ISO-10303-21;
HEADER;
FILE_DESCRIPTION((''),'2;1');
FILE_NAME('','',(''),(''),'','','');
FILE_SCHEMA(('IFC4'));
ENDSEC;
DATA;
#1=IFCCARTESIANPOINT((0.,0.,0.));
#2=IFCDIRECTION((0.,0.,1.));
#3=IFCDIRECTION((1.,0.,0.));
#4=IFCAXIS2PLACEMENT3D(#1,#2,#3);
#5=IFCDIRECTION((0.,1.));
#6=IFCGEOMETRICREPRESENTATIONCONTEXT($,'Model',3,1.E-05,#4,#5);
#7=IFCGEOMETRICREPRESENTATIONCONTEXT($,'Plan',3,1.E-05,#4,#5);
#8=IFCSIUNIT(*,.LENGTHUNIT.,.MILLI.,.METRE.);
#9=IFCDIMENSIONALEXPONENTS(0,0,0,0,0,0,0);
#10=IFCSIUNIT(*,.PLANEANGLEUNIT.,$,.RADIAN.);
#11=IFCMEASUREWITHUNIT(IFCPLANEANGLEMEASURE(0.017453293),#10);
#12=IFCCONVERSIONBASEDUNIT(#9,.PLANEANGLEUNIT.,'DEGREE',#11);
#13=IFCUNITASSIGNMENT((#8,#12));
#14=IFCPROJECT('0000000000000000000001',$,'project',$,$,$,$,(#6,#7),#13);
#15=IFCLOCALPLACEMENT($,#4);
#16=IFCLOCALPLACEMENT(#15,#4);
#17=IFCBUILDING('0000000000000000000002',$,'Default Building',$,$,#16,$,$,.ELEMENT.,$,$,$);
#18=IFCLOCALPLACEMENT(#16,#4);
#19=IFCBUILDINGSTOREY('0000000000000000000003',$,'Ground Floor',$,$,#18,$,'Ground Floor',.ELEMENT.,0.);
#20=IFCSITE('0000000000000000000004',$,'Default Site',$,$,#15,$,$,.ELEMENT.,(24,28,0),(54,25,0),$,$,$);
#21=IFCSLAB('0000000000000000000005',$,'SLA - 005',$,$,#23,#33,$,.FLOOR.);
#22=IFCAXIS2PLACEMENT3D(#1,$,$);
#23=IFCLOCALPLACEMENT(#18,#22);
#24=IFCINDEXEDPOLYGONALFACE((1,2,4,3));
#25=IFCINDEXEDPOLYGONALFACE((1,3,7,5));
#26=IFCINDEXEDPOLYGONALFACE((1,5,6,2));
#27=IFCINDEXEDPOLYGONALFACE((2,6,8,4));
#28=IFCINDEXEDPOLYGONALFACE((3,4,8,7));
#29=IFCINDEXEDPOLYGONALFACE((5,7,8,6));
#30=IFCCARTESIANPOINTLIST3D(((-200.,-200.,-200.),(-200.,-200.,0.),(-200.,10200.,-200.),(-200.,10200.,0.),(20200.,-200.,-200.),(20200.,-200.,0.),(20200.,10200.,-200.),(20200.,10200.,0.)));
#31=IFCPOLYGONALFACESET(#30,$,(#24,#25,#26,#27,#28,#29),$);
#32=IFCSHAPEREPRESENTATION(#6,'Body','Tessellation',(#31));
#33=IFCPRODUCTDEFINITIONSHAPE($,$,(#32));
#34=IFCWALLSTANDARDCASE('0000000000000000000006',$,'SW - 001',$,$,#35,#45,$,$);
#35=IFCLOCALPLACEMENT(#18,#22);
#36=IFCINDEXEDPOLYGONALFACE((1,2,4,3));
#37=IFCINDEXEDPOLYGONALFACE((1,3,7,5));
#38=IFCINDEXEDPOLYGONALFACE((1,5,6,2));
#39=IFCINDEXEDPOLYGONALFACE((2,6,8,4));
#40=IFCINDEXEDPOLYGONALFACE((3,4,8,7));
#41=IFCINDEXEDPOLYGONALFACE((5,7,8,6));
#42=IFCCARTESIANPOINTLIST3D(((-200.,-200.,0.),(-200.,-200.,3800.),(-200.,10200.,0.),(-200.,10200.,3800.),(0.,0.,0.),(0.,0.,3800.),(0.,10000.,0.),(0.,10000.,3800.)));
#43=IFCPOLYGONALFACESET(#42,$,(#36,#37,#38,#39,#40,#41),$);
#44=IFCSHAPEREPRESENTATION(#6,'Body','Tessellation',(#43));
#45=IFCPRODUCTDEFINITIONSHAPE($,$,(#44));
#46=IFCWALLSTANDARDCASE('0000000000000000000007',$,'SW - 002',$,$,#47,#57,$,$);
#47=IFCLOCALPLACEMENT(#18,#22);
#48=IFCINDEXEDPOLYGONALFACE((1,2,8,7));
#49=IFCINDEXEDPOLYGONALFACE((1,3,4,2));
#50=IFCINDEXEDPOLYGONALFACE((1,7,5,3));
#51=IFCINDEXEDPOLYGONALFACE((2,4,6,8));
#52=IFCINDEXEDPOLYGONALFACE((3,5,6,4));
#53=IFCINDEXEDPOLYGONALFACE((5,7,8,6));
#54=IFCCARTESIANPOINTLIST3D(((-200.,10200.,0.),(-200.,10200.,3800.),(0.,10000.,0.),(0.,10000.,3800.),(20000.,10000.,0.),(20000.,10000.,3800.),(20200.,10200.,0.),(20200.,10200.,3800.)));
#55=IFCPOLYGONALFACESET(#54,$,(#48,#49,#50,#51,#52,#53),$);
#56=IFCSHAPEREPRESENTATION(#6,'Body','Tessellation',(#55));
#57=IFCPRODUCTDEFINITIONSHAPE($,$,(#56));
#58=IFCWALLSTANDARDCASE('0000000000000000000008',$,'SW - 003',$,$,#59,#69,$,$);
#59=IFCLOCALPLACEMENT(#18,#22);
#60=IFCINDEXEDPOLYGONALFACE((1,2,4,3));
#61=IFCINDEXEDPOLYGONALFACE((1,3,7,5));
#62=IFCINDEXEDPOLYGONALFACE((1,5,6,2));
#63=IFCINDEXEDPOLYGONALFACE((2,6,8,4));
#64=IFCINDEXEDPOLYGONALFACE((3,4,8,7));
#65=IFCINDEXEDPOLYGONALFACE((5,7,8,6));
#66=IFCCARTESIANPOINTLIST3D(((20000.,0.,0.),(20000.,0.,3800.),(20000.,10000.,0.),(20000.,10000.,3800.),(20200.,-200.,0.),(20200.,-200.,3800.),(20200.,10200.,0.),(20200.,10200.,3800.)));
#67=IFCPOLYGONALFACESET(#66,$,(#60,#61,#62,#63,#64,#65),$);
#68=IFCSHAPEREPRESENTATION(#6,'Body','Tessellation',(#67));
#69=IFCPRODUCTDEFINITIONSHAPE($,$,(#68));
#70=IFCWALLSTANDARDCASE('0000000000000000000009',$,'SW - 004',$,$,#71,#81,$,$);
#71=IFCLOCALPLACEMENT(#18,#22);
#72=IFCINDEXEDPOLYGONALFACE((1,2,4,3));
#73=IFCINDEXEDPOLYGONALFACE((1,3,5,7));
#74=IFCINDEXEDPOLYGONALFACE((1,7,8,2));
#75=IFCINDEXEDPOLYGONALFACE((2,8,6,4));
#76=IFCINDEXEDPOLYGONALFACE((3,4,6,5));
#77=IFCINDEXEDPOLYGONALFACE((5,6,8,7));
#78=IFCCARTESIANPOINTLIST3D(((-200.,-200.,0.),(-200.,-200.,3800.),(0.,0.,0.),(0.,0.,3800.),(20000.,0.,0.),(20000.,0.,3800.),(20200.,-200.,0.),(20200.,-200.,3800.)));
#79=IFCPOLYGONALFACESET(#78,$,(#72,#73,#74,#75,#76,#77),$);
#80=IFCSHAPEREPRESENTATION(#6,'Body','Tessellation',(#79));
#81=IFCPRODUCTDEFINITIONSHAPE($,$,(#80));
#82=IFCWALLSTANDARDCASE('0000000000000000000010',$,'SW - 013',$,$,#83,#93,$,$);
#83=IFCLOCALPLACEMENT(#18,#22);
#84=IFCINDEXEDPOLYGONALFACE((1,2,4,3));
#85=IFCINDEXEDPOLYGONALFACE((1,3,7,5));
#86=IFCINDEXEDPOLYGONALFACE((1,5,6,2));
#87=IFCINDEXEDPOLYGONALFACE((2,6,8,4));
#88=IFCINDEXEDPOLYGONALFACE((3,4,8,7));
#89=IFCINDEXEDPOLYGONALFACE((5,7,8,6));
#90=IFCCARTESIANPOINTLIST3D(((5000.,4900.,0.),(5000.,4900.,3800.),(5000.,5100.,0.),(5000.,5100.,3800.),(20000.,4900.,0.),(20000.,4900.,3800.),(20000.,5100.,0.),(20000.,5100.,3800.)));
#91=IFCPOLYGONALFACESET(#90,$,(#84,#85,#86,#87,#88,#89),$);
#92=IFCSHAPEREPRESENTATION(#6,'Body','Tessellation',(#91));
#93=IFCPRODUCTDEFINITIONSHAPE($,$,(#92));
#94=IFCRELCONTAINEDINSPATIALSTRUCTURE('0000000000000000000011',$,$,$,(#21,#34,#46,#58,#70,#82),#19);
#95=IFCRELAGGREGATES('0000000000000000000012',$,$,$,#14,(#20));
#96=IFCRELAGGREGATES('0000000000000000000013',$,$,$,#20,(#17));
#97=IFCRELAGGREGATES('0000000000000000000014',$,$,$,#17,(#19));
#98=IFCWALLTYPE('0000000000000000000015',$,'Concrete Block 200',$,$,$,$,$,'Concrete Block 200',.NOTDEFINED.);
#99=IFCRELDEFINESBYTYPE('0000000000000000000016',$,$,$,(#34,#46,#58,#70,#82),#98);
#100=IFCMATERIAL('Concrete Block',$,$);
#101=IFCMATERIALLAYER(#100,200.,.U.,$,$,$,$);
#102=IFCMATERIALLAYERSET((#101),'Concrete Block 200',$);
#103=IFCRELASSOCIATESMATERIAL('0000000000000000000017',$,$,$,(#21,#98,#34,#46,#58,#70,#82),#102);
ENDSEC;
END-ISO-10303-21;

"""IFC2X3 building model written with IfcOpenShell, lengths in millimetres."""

from ifc_helpers import new_model, entity, si_unit, converted_unit, direction, frame, origin_with_axes, place, context, project, spatial, polyline, outline, extrude, material, layer, layer_set, layer_usage, type_object, element, save


model = new_model("IFC2X3")

# Units and contexts
model_context = context("Model", 3, precision=1e-05, world=origin_with_axes(), true_north=direction((0.0, 1.0)))
plan_context = context("Plan", 3, precision=1e-05, world=origin_with_axes(), true_north=direction((0.0, 1.0)))
ifc_project = project(units=[si_unit("LENGTHUNIT", "METRE", prefix="MILLI"), converted_unit("PLANEANGLEUNIT", "DEGREE", entity("IfcPlaneAngleMeasure", 0.017453293), si_unit("PLANEANGLEUNIT", "RADIAN"), dimensions=[0, 0, 0, 0, 0, 0, 0])], contexts=[model_context, plan_context])

# Site, building, storey
site_placement = place(None, origin_with_axes())
site = spatial("IfcSite", under=ifc_project, at=site_placement, Name="Default Site", CompositionType="ELEMENT", RefLatitude=(24, 28, 0), RefLongitude=(54, 25, 0))
building_placement = place(site_placement, origin_with_axes())
building = spatial("IfcBuilding", under=site, at=building_placement, Name="Default Building", CompositionType="ELEMENT")
storey_placement = place(building_placement, origin_with_axes())
storey = spatial("IfcBuildingStorey", under=building, at=storey_placement, Name="Ground Floor", LongName="Ground Floor", CompositionType="ELEMENT", Elevation=0.0)

# Slab
ifc_material = material(Name="Concrete Block")
ifc_layer = layer(ifc_material, 200.0, ventilated="UNKNOWN")
ifc_layer_set = layer_set([ifc_layer], Name="Concrete Block 200")
ifc_layer_usage_1 = layer_usage(ifc_layer_set, "AXIS3", "NEGATIVE", 200.0)
slab_placement = place(storey_placement, frame((-200.0, 10200.0, -200.0), z_axis=(0.0, 0.0, 1.0), x_axis=(1.0, 0.0, 0.0)))
element("IfcSlab", 1, at=slab_placement, inside=storey, material=ifc_layer_usage_1, Name="SLA - 005", PredefinedType="FLOOR", context=model_context, shape_type="SweptSolid", body=[
    extrude(outline(polyline([(0.0, 0.0), (20400.0, 0.0), (20400.0, -10400.0), (0.0, -10400.0), (0.0, 0.0)])), origin_with_axes(), (0.0, 0.0, 1.0), 200.0),
])

# Walls
ifc_layer_usage_2 = layer_usage(ifc_layer_set, "AXIS2", "POSITIVE", 0.0)
wall_type = type_object("IfcWallType", Name="Concrete Block 200", ElementType="Concrete Block 200", PredefinedType="NOTDEFINED", material=ifc_layer_set)
wall_1_placement = place(storey_placement, frame((0.0, 0.0, 0.0), z_axis=(0.0, 0.0, 1.0), x_axis=(0.0, 1.0, 0.0)))
element("IfcWallStandardCase", 2, at=wall_1_placement, inside=storey, type_object=wall_type, material=ifc_layer_usage_2, Name="SW - 001", context=model_context, shape_type="SweptSolid", body=[
    extrude(outline(polyline([(0.0, 0.0), (10000.0, 0.0), (10200.0, 200.0), (-200.0, 200.0), (0.0, 0.0)])), origin_with_axes(), (0.0, 0.0, 1.0), 3800.0),
])
ifc_layer_usage_3 = layer_usage(ifc_layer_set, "AXIS2", "POSITIVE", 0.0)
wall_2_placement = place(storey_placement, frame((0.0, 10000.0, 0.0), z_axis=(0.0, 0.0, 1.0), x_axis=(1.0, 0.0, 0.0)))
element("IfcWallStandardCase", 3, at=wall_2_placement, inside=storey, type_object=wall_type, material=ifc_layer_usage_3, Name="SW - 002", context=model_context, shape_type="SweptSolid", body=[
    extrude(outline(polyline([(0.0, 0.0), (20000.0, 0.0), (20200.0, 200.0), (-200.0, 200.0), (0.0, 0.0)])), origin_with_axes(), (0.0, 0.0, 1.0), 3800.0),
])
ifc_layer_usage_4 = layer_usage(ifc_layer_set, "AXIS2", "POSITIVE", 0.0)
wall_3_placement = place(storey_placement, frame((20000.0, 10000.0, 0.0), z_axis=(0.0, 0.0, 1.0), x_axis=(0.0, -1.0, 0.0)))
element("IfcWallStandardCase", 4, at=wall_3_placement, inside=storey, type_object=wall_type, material=ifc_layer_usage_4, Name="SW - 003", context=model_context, shape_type="SweptSolid", body=[
    extrude(outline(polyline([(0.0, 0.0), (10000.0, 0.0), (10200.0, 200.0), (-200.0, 200.0), (0.0, 0.0)])), origin_with_axes(), (0.0, 0.0, 1.0), 3800.0),
])
ifc_layer_usage_5 = layer_usage(ifc_layer_set, "AXIS2", "POSITIVE", 0.0)
wall_4_placement = place(storey_placement, frame((20000.0, 0.0, 0.0), z_axis=(0.0, 0.0, 1.0), x_axis=(-1.0, 0.0, 0.0)))
element("IfcWallStandardCase", 5, at=wall_4_placement, inside=storey, type_object=wall_type, material=ifc_layer_usage_5, Name="SW - 004", context=model_context, shape_type="SweptSolid", body=[
    extrude(outline(polyline([(0.0, 0.0), (20000.0, 0.0), (20200.0, 200.0), (-200.0, 200.0), (0.0, 0.0)])), origin_with_axes(), (0.0, 0.0, 1.0), 3800.0),
])
ifc_layer_usage_6 = layer_usage(ifc_layer_set, "AXIS2", "NEGATIVE", 100.0)
wall_5_placement = place(storey_placement, frame((5000.0, 5000.0, 0.0), z_axis=(0.0, 0.0, 1.0), x_axis=(1.0, 0.0, 0.0)))
element("IfcWallStandardCase", 6, at=wall_5_placement, inside=storey, type_object=wall_type, material=ifc_layer_usage_6, Name="SW - 013", context=model_context, shape_type="SweptSolid", body=[
    extrude(outline(polyline([(0.0, -100.0), (15000.0, -100.0), (15000.0, 100.0), (0.0, 100.0), (0.0, -100.0)])), origin_with_axes(), (0.0, 0.0, 1.0), 3800.0),
])

save(model, "model.ifc")
